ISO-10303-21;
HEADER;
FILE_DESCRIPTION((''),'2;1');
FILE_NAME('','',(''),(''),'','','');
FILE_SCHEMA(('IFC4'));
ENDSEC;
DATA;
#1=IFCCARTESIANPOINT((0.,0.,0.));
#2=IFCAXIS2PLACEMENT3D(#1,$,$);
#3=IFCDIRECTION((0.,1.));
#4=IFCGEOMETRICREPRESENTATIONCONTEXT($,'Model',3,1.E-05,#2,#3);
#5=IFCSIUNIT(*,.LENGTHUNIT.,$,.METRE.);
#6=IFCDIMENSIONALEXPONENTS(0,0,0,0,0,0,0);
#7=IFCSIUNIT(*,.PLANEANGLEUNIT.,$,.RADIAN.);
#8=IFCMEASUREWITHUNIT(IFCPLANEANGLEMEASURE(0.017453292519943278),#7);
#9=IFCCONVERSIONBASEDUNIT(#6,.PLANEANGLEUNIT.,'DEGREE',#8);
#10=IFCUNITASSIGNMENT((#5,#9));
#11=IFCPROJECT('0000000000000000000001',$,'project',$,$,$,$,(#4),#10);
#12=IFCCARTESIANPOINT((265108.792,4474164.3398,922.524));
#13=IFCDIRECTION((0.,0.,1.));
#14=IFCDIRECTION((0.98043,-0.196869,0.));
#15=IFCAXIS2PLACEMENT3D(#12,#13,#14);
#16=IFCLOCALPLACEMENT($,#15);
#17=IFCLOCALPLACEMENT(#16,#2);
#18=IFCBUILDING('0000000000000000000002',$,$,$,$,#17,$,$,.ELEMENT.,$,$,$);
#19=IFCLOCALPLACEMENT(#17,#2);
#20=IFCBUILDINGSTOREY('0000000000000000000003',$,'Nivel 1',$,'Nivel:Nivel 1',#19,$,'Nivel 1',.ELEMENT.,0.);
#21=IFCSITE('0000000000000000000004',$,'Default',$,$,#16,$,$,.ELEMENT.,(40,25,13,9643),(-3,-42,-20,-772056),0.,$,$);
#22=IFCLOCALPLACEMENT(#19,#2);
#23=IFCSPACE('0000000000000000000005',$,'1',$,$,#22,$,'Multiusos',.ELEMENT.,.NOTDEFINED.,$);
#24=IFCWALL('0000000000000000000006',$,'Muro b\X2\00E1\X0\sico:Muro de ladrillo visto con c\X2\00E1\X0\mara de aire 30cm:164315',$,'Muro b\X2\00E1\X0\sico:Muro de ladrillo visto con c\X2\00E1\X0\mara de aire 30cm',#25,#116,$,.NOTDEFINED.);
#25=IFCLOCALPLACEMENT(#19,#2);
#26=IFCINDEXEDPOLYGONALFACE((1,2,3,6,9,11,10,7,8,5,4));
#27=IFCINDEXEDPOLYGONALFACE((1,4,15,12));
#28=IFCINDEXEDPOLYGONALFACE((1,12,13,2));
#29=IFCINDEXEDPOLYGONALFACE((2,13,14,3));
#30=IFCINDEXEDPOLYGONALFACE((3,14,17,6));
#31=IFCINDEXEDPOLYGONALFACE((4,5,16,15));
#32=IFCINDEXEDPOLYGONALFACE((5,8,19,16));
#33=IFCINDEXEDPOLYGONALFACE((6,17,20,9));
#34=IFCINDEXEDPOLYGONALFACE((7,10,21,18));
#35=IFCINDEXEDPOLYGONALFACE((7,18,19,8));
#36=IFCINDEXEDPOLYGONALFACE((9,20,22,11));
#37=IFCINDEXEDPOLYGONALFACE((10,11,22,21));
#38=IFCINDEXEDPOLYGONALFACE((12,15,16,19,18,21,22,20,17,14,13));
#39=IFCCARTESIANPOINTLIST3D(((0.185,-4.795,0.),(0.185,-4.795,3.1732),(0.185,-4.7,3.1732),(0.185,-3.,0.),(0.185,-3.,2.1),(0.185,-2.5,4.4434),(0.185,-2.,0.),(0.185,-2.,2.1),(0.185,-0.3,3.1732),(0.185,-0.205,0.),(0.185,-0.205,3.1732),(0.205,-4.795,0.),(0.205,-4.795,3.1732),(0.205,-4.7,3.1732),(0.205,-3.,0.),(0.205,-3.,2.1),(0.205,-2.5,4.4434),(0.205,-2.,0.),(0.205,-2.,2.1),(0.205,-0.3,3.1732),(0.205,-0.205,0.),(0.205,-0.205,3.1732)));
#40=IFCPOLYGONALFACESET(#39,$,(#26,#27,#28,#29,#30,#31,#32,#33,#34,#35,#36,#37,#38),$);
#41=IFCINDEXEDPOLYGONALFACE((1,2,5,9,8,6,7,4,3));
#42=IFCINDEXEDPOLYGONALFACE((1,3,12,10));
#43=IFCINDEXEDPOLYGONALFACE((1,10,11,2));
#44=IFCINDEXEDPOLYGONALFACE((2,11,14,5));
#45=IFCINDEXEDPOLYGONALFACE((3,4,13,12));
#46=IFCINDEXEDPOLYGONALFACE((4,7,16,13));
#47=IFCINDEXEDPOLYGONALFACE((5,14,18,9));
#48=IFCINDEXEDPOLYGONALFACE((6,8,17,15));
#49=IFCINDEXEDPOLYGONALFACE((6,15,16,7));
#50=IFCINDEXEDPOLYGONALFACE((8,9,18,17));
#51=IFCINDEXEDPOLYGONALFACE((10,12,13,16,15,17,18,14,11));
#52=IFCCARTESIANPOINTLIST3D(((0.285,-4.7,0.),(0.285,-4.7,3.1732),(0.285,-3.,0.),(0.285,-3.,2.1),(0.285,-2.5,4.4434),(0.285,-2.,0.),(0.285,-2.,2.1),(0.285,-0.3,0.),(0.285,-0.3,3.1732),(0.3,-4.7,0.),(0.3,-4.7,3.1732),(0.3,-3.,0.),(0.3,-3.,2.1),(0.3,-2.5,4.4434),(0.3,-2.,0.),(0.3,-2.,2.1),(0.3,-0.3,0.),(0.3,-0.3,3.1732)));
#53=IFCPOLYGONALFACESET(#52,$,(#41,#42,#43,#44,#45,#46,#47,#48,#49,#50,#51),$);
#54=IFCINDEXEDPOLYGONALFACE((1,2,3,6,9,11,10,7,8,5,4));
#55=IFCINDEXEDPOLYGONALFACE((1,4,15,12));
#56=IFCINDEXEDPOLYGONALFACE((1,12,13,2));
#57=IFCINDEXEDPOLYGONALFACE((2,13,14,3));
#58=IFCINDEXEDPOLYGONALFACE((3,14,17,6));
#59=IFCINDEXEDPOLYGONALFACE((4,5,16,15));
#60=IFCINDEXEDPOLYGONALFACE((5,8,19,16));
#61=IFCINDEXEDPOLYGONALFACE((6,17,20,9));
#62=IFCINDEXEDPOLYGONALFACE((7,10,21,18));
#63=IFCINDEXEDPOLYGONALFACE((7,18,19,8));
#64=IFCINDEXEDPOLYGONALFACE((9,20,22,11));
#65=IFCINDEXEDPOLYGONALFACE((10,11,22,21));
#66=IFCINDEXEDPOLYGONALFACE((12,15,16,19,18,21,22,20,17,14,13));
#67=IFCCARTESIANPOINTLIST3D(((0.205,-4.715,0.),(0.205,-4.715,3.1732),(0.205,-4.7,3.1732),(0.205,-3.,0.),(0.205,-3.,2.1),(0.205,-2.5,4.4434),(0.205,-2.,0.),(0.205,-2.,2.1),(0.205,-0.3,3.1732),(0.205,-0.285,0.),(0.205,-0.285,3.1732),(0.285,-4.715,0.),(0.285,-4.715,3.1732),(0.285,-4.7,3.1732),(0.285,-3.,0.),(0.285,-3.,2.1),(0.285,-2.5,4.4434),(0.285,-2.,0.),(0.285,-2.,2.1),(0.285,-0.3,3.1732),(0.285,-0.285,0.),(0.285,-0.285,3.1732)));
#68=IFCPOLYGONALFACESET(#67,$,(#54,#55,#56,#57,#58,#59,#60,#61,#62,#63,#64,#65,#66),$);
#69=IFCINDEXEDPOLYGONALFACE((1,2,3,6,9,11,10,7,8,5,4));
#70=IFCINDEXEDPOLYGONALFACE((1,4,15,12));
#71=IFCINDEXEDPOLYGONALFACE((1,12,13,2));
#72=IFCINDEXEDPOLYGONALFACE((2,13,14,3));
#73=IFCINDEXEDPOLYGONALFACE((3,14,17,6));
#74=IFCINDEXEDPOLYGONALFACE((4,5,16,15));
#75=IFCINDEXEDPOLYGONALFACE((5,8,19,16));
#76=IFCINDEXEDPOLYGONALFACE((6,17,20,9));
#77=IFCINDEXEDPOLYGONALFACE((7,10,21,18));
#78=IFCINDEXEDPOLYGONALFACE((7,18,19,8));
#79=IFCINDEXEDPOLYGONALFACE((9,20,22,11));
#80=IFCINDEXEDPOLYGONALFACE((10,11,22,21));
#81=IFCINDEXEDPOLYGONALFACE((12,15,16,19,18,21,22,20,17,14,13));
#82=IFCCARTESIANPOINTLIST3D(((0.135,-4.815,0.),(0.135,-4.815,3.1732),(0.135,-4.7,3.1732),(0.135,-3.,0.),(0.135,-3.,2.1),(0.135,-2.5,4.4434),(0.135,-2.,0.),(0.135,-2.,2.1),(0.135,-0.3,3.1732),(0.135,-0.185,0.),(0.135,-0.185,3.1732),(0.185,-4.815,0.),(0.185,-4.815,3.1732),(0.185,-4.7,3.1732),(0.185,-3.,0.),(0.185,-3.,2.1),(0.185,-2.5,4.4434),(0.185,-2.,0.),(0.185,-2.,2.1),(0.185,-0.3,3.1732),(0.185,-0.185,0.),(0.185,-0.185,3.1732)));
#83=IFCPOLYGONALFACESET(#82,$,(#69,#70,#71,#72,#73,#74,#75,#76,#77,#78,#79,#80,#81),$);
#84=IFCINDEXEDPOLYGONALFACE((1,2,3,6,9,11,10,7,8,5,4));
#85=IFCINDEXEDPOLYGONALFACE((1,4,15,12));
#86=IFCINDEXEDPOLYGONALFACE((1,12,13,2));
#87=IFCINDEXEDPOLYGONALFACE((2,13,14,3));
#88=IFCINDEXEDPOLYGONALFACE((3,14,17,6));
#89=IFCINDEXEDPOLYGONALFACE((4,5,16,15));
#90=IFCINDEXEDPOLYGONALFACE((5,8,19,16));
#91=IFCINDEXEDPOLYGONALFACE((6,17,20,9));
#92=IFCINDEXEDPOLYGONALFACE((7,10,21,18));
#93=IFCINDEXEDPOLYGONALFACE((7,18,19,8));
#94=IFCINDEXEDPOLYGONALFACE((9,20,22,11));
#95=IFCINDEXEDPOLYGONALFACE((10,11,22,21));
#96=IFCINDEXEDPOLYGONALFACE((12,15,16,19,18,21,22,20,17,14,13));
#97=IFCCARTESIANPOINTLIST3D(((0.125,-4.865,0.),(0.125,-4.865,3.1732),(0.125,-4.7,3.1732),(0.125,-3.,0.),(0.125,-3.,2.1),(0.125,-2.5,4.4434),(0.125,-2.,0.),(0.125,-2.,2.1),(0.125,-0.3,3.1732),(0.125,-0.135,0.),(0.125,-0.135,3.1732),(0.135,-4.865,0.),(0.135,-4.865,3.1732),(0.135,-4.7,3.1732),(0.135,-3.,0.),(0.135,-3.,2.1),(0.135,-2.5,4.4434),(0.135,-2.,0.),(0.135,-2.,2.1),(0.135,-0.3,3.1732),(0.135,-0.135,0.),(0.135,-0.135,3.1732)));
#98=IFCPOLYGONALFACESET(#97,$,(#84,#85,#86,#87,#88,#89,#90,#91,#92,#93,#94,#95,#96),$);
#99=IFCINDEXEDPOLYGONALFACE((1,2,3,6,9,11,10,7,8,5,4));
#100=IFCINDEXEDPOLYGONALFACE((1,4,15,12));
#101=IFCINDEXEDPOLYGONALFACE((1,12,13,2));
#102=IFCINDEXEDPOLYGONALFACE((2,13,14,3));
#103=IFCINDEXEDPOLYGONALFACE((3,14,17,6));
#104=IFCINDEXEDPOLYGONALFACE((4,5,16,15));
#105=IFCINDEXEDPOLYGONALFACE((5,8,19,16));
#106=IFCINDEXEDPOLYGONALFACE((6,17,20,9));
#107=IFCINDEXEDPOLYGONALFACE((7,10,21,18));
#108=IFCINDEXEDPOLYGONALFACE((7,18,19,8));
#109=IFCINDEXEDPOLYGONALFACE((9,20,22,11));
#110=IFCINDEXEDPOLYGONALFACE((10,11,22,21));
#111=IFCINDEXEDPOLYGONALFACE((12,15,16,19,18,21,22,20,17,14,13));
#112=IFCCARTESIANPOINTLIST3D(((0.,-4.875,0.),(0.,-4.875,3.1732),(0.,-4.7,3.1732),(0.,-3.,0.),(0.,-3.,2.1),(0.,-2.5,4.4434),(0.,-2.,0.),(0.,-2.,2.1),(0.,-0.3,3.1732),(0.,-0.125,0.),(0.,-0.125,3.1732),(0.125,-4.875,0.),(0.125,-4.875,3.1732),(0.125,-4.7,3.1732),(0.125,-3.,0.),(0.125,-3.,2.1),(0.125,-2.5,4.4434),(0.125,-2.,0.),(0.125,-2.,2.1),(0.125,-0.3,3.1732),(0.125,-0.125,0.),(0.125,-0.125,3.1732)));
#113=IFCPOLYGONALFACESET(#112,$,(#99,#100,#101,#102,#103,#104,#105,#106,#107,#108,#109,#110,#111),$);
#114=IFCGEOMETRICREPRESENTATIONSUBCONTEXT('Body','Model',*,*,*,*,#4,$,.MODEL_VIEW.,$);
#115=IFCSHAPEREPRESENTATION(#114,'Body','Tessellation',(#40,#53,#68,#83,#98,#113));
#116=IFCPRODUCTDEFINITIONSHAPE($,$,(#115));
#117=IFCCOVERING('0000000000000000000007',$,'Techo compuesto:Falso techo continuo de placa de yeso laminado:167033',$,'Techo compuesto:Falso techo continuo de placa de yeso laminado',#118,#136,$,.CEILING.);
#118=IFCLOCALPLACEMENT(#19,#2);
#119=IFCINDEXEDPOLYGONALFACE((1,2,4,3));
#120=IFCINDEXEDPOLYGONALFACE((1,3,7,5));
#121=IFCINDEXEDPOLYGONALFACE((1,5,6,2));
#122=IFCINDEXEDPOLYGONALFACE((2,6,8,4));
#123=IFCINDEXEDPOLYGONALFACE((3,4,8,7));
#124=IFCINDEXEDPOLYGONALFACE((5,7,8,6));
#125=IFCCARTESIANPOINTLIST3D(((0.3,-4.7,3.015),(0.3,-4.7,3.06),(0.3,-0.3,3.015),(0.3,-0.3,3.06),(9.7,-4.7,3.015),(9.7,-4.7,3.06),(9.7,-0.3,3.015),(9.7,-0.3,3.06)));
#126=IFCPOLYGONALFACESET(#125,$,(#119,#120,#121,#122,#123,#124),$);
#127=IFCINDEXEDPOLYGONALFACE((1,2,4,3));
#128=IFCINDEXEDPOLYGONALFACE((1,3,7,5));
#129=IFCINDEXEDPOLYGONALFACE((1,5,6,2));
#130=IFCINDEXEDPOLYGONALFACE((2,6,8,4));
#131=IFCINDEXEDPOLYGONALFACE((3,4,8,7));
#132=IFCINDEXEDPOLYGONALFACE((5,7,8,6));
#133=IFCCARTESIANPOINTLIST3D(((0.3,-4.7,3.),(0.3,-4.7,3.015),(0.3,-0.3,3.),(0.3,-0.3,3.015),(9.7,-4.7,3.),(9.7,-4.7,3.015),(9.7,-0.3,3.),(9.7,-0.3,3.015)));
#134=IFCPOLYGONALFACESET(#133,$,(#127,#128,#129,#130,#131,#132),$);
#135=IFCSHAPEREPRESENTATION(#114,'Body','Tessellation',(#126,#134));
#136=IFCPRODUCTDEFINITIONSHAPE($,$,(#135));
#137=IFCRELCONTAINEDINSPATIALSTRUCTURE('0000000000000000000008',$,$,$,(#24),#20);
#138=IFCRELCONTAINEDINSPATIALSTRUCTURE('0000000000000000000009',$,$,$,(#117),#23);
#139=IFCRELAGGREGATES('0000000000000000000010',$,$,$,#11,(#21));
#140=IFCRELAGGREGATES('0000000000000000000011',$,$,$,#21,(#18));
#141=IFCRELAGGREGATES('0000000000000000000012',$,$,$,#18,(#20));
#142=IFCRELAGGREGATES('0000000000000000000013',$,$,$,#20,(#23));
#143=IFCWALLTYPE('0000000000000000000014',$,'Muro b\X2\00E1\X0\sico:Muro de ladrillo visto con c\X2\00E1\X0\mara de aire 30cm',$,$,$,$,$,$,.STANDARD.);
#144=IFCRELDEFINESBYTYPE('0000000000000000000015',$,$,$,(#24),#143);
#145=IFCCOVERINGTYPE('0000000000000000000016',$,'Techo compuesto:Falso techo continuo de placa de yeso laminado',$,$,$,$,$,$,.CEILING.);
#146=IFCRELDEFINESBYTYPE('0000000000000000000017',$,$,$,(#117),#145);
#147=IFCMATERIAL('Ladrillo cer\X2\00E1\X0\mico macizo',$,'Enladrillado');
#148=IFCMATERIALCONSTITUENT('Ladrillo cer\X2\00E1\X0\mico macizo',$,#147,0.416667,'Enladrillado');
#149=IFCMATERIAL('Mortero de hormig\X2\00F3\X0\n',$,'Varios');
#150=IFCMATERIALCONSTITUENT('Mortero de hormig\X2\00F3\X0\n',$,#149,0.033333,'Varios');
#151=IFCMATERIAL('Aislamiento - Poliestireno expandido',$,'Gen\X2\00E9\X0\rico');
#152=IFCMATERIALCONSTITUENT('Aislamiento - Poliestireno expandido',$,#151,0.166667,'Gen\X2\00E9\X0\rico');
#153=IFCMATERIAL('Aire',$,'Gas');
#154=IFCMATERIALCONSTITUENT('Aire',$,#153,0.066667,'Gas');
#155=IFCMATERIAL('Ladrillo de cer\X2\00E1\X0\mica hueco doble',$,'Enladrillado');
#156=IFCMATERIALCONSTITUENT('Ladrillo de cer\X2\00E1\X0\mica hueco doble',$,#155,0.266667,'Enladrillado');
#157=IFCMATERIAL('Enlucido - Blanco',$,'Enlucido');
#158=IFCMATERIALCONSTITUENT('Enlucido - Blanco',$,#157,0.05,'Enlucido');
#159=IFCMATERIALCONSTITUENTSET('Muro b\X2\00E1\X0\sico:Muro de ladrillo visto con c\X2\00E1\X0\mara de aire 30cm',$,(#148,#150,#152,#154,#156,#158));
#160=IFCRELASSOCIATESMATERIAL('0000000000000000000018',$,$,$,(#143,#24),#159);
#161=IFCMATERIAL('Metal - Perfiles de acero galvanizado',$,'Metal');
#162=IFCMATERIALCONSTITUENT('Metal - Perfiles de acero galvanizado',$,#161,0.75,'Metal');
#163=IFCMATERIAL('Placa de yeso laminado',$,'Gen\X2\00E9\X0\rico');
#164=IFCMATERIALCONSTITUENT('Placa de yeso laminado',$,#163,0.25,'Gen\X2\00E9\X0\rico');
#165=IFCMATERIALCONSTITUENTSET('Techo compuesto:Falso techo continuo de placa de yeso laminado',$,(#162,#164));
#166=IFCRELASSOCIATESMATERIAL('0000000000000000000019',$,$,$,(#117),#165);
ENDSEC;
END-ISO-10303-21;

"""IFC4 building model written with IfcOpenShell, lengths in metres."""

from ifc_helpers import new_model, entity, si_unit, converted_unit, direction, frame, origin, place, context, subcontext, project, spatial, indexed_curve, outline, extrude, material, constituent, constituent_set, type_object, element, save


model = new_model("IFC4")

# Units and contexts
model_context = context("Model", 3, precision=1e-05, world=origin(), true_north=direction((0.0, 1.0)))
body_context = subcontext(model_context, "Body", "Model", "MODEL_VIEW")
ifc_project = project(units=[si_unit("LENGTHUNIT", "METRE"), converted_unit("PLANEANGLEUNIT", "DEGREE", entity("IfcPlaneAngleMeasure", 0.017453292519943278), si_unit("PLANEANGLEUNIT", "RADIAN"), dimensions=[0, 0, 0, 0, 0, 0, 0])], contexts=[model_context])

# Site, building, storey
site_placement = place(None, frame((265108.792, 4474164.3398, 922.524), z_axis=(0.0, 0.0, 1.0), x_axis=(0.98043, -0.196869, 0.0)))
site = spatial("IfcSite", under=ifc_project, at=site_placement, Name="Default", CompositionType="ELEMENT", RefLatitude=(40, 25, 13, 9643), RefLongitude=(-3, -42, -20, -772056), RefElevation=0.0)
building_placement = place(site_placement, origin())
building = spatial("IfcBuilding", under=site, at=building_placement, CompositionType="ELEMENT")
storey_placement = place(building_placement, origin())
storey = spatial("IfcBuildingStorey", under=building, at=storey_placement, Name="Nivel 1", ObjectType="Nivel:Nivel 1", LongName="Nivel 1", CompositionType="ELEMENT", Elevation=0.0)

# Shared definitions
ifc_material_1 = material(Name="Ladrillo cerámico macizo", Category="Enladrillado")
ifc_constituent_1 = constituent(ifc_material_1, Name="Ladrillo cerámico macizo", Category="Enladrillado", fraction=0.416667)
ifc_material_2 = material(Name="Mortero de hormigón", Category="Varios")
ifc_constituent_2 = constituent(ifc_material_2, Name="Mortero de hormigón", Category="Varios", fraction=0.033333)
ifc_material_3 = material(Name="Aislamiento - Poliestireno expandido", Category="Genérico")
ifc_constituent_3 = constituent(ifc_material_3, Name="Aislamiento - Poliestireno expandido", Category="Genérico", fraction=0.166667)
ifc_material_4 = material(Name="Aire", Category="Gas")
ifc_constituent_4 = constituent(ifc_material_4, Name="Aire", Category="Gas", fraction=0.066667)
ifc_material_5 = material(Name="Ladrillo de cerámica hueco doble", Category="Enladrillado")
ifc_constituent_5 = constituent(ifc_material_5, Name="Ladrillo de cerámica hueco doble", Category="Enladrillado", fraction=0.266667)
ifc_material_6 = material(Name="Enlucido - Blanco", Category="Enlucido")
ifc_constituent_6 = constituent(ifc_material_6, Name="Enlucido - Blanco", Category="Enlucido", fraction=0.05)
ifc_constituent_set_1 = constituent_set(constituents=[ifc_constituent_1, ifc_constituent_2, ifc_constituent_3, ifc_constituent_4, ifc_constituent_5, ifc_constituent_6], Name="Muro básico:Muro de ladrillo visto con cámara de aire 30cm")
wall_type = type_object("IfcWallType", Name="Muro básico:Muro de ladrillo visto con cámara de aire 30cm", PredefinedType="STANDARD", material=ifc_constituent_set_1)

# Wall, opening
wall_1_placement = place(storey_placement, frame((0.15, -4.7, 0.0), z_axis=(0.0, 0.0, 1.0), x_axis=(0.0, 1.0, 0.0)))
wall_1 = element("IfcWall", 1, at=wall_1_placement, inside=storey, type_object=wall_type, material=ifc_constituent_set_1, Name="Muro básico:Muro de ladrillo visto con cámara de aire 30cm:164315", ObjectType="Muro básico:Muro de ladrillo visto con cámara de aire 30cm", PredefinedType="NOTDEFINED", context=body_context, shape_type="SweptSolid", body=[
    extrude(outline(indexed_curve([(-1.9397, -0.5), (-1.9397, -2.295), (1.2336, -2.295), (1.2336, -2.2), (2.5037, 0.0), (1.2336, 2.2), (1.2336, 2.295), (-1.9397, 2.295), (-1.9397, 0.5), (0.1603, 0.5), (0.1603, -0.5), (-1.9397, -0.5)], self_intersect=False)), frame((2.2, -0.035, 1.9397), z_axis=(0.0, 1.0, 0.0), x_axis=(0.0, 0.0, 1.0)), (0.0, 0.0, -1.0), 0.02),
    extrude(outline(indexed_curve([(-1.6655, -0.5), (-1.6655, -2.2), (1.5077, -2.2), (2.7778, 0.0), (1.5077, 2.2), (-1.6655, 2.2), (-1.6655, 0.5), (0.4345, 0.5), (0.4345, -0.5), (-1.6655, -0.5)], self_intersect=False)), frame((2.2, -0.135, 1.6655), z_axis=(0.0, 1.0, 0.0), x_axis=(0.0, 0.0, 1.0)), (0.0, 0.0, -1.0), 0.015),
    extrude(outline(indexed_curve([(-1.9397, -0.5), (-1.9397, -2.215), (1.2336, -2.215), (1.2336, -2.2), (2.5037, 0.0), (1.2336, 2.2), (1.2336, 2.215), (-1.9397, 2.215), (-1.9397, 0.5), (0.1603, 0.5), (0.1603, -0.5), (-1.9397, -0.5)], self_intersect=False)), frame((2.2, -0.055, 1.9397), z_axis=(0.0, 1.0, 0.0), x_axis=(0.0, 0.0, 1.0)), (0.0, 0.0, -1.0), 0.08),
    extrude(outline(indexed_curve([(-1.9397, -0.5), (-1.9397, -2.315), (1.2336, -2.315), (1.2336, -2.2), (2.5037, 0.0), (1.2336, 2.2), (1.2336, 2.315), (-1.9397, 2.315), (-1.9397, 0.5), (0.1603, 0.5), (0.1603, -0.5), (-1.9397, -0.5)], self_intersect=False)), frame((2.2, 0.015, 1.9397), z_axis=(0.0, 1.0, 0.0), x_axis=(0.0, 0.0, 1.0)), (0.0, 0.0, -1.0), 0.05),
    extrude(outline(indexed_curve([(-1.9397, -0.5), (-1.9397, -2.365), (1.2336, -2.365), (1.2336, -2.2), (2.5037, 0.0), (1.2336, 2.2), (1.2336, 2.365), (-1.9397, 2.365), (-1.9397, 0.5), (0.1603, 0.5), (0.1603, -0.5), (-1.9397, -0.5)], self_intersect=False)), frame((2.2, 0.025, 1.9397), z_axis=(0.0, 1.0, 0.0), x_axis=(0.0, 0.0, 1.0)), (0.0, 0.0, -1.0), 0.01),
    extrude(outline(indexed_curve([(-1.9397, -2.375), (1.2336, -2.375), (1.2336, -2.2), (2.5037, 0.0), (1.2336, 2.2), (1.2336, 2.375), (-1.9397, 2.375), (-1.9397, 0.5), (0.1603, 0.5), (0.1603, -0.5), (-1.9397, -0.5), (-1.9397, -2.375)], self_intersect=False)), frame((2.2, 0.15, 1.9397), z_axis=(0.0, -1.0, 0.0), x_axis=(0.0, 0.0, 1.0)), (0.0, 0.0, 1.0), 0.125),
])
opening_1_placement = place(wall_1_placement, frame((2.7, 0.15, 0.0)))
element("IfcOpeningElement", 2, at=opening_1_placement, cuts=wall_1, PredefinedType="OPENING", context=body_context, shape_type="SweptSolid", body=[
    extrude(outline(indexed_curve([(0.0, 1.0), (0.0, 0.0), (2.1, 0.0), (2.1, 1.0), (0.0, 1.0)], self_intersect=False)), frame((0.0, 0.0, 0.0), z_axis=(0.0, -1.0, 0.0), x_axis=(0.0, 0.0, 1.0)), (0.0, 0.0, 1.0), 0.3),
])

# Shared definitions
space_placement = place(storey_placement, origin())
space = spatial("IfcSpace", under=storey, at=space_placement, Name="1", LongName="Multiusos", CompositionType="ELEMENT", PredefinedType="NOTDEFINED")

# Covering
ifc_material_7 = material(Name="Metal - Perfiles de acero galvanizado", Category="Metal")
ifc_constituent_7 = constituent(ifc_material_7, Name="Metal - Perfiles de acero galvanizado", Category="Metal", fraction=0.75)
ifc_material_8 = material(Name="Placa de yeso laminado", Category="Genérico")
ifc_constituent_8 = constituent(ifc_material_8, Name="Placa de yeso laminado", Category="Genérico", fraction=0.25)
ifc_constituent_set_2 = constituent_set(constituents=[ifc_constituent_7, ifc_constituent_8], Name="Techo compuesto:Falso techo continuo de placa de yeso laminado")
covering_type = type_object("IfcCoveringType", Name="Techo compuesto:Falso techo continuo de placa de yeso laminado", PredefinedType="CEILING")
covering_placement = place(space_placement, origin())
element("IfcCovering", 3, at=covering_placement, inside=space, type_object=covering_type, material=ifc_constituent_set_2, Name="Techo compuesto:Falso techo continuo de placa de yeso laminado:167033", ObjectType="Techo compuesto:Falso techo continuo de placa de yeso laminado", PredefinedType="CEILING", context=body_context, shape_type="SweptSolid", body=[
    extrude(outline(indexed_curve([(-4.7, -2.2), (4.7, -2.2), (4.7, 2.2), (-4.7, 2.2), (-4.7, -2.2)], self_intersect=False)), frame((5.0, -2.5, 3.015)), (0.0, 0.0, 1.0), 0.045),
    extrude(outline(indexed_curve([(-2.2, -4.7), (2.2, -4.7), (2.2, 4.7), (-2.2, 4.7), (-2.2, -4.7)], self_intersect=False)), frame((5.0, -2.5, 3.0), z_axis=(0.0, 0.0, 1.0), x_axis=(0.0, -1.0, 0.0)), (0.0, 0.0, 1.0), 0.015),
])

save(model, "model.ifc")
